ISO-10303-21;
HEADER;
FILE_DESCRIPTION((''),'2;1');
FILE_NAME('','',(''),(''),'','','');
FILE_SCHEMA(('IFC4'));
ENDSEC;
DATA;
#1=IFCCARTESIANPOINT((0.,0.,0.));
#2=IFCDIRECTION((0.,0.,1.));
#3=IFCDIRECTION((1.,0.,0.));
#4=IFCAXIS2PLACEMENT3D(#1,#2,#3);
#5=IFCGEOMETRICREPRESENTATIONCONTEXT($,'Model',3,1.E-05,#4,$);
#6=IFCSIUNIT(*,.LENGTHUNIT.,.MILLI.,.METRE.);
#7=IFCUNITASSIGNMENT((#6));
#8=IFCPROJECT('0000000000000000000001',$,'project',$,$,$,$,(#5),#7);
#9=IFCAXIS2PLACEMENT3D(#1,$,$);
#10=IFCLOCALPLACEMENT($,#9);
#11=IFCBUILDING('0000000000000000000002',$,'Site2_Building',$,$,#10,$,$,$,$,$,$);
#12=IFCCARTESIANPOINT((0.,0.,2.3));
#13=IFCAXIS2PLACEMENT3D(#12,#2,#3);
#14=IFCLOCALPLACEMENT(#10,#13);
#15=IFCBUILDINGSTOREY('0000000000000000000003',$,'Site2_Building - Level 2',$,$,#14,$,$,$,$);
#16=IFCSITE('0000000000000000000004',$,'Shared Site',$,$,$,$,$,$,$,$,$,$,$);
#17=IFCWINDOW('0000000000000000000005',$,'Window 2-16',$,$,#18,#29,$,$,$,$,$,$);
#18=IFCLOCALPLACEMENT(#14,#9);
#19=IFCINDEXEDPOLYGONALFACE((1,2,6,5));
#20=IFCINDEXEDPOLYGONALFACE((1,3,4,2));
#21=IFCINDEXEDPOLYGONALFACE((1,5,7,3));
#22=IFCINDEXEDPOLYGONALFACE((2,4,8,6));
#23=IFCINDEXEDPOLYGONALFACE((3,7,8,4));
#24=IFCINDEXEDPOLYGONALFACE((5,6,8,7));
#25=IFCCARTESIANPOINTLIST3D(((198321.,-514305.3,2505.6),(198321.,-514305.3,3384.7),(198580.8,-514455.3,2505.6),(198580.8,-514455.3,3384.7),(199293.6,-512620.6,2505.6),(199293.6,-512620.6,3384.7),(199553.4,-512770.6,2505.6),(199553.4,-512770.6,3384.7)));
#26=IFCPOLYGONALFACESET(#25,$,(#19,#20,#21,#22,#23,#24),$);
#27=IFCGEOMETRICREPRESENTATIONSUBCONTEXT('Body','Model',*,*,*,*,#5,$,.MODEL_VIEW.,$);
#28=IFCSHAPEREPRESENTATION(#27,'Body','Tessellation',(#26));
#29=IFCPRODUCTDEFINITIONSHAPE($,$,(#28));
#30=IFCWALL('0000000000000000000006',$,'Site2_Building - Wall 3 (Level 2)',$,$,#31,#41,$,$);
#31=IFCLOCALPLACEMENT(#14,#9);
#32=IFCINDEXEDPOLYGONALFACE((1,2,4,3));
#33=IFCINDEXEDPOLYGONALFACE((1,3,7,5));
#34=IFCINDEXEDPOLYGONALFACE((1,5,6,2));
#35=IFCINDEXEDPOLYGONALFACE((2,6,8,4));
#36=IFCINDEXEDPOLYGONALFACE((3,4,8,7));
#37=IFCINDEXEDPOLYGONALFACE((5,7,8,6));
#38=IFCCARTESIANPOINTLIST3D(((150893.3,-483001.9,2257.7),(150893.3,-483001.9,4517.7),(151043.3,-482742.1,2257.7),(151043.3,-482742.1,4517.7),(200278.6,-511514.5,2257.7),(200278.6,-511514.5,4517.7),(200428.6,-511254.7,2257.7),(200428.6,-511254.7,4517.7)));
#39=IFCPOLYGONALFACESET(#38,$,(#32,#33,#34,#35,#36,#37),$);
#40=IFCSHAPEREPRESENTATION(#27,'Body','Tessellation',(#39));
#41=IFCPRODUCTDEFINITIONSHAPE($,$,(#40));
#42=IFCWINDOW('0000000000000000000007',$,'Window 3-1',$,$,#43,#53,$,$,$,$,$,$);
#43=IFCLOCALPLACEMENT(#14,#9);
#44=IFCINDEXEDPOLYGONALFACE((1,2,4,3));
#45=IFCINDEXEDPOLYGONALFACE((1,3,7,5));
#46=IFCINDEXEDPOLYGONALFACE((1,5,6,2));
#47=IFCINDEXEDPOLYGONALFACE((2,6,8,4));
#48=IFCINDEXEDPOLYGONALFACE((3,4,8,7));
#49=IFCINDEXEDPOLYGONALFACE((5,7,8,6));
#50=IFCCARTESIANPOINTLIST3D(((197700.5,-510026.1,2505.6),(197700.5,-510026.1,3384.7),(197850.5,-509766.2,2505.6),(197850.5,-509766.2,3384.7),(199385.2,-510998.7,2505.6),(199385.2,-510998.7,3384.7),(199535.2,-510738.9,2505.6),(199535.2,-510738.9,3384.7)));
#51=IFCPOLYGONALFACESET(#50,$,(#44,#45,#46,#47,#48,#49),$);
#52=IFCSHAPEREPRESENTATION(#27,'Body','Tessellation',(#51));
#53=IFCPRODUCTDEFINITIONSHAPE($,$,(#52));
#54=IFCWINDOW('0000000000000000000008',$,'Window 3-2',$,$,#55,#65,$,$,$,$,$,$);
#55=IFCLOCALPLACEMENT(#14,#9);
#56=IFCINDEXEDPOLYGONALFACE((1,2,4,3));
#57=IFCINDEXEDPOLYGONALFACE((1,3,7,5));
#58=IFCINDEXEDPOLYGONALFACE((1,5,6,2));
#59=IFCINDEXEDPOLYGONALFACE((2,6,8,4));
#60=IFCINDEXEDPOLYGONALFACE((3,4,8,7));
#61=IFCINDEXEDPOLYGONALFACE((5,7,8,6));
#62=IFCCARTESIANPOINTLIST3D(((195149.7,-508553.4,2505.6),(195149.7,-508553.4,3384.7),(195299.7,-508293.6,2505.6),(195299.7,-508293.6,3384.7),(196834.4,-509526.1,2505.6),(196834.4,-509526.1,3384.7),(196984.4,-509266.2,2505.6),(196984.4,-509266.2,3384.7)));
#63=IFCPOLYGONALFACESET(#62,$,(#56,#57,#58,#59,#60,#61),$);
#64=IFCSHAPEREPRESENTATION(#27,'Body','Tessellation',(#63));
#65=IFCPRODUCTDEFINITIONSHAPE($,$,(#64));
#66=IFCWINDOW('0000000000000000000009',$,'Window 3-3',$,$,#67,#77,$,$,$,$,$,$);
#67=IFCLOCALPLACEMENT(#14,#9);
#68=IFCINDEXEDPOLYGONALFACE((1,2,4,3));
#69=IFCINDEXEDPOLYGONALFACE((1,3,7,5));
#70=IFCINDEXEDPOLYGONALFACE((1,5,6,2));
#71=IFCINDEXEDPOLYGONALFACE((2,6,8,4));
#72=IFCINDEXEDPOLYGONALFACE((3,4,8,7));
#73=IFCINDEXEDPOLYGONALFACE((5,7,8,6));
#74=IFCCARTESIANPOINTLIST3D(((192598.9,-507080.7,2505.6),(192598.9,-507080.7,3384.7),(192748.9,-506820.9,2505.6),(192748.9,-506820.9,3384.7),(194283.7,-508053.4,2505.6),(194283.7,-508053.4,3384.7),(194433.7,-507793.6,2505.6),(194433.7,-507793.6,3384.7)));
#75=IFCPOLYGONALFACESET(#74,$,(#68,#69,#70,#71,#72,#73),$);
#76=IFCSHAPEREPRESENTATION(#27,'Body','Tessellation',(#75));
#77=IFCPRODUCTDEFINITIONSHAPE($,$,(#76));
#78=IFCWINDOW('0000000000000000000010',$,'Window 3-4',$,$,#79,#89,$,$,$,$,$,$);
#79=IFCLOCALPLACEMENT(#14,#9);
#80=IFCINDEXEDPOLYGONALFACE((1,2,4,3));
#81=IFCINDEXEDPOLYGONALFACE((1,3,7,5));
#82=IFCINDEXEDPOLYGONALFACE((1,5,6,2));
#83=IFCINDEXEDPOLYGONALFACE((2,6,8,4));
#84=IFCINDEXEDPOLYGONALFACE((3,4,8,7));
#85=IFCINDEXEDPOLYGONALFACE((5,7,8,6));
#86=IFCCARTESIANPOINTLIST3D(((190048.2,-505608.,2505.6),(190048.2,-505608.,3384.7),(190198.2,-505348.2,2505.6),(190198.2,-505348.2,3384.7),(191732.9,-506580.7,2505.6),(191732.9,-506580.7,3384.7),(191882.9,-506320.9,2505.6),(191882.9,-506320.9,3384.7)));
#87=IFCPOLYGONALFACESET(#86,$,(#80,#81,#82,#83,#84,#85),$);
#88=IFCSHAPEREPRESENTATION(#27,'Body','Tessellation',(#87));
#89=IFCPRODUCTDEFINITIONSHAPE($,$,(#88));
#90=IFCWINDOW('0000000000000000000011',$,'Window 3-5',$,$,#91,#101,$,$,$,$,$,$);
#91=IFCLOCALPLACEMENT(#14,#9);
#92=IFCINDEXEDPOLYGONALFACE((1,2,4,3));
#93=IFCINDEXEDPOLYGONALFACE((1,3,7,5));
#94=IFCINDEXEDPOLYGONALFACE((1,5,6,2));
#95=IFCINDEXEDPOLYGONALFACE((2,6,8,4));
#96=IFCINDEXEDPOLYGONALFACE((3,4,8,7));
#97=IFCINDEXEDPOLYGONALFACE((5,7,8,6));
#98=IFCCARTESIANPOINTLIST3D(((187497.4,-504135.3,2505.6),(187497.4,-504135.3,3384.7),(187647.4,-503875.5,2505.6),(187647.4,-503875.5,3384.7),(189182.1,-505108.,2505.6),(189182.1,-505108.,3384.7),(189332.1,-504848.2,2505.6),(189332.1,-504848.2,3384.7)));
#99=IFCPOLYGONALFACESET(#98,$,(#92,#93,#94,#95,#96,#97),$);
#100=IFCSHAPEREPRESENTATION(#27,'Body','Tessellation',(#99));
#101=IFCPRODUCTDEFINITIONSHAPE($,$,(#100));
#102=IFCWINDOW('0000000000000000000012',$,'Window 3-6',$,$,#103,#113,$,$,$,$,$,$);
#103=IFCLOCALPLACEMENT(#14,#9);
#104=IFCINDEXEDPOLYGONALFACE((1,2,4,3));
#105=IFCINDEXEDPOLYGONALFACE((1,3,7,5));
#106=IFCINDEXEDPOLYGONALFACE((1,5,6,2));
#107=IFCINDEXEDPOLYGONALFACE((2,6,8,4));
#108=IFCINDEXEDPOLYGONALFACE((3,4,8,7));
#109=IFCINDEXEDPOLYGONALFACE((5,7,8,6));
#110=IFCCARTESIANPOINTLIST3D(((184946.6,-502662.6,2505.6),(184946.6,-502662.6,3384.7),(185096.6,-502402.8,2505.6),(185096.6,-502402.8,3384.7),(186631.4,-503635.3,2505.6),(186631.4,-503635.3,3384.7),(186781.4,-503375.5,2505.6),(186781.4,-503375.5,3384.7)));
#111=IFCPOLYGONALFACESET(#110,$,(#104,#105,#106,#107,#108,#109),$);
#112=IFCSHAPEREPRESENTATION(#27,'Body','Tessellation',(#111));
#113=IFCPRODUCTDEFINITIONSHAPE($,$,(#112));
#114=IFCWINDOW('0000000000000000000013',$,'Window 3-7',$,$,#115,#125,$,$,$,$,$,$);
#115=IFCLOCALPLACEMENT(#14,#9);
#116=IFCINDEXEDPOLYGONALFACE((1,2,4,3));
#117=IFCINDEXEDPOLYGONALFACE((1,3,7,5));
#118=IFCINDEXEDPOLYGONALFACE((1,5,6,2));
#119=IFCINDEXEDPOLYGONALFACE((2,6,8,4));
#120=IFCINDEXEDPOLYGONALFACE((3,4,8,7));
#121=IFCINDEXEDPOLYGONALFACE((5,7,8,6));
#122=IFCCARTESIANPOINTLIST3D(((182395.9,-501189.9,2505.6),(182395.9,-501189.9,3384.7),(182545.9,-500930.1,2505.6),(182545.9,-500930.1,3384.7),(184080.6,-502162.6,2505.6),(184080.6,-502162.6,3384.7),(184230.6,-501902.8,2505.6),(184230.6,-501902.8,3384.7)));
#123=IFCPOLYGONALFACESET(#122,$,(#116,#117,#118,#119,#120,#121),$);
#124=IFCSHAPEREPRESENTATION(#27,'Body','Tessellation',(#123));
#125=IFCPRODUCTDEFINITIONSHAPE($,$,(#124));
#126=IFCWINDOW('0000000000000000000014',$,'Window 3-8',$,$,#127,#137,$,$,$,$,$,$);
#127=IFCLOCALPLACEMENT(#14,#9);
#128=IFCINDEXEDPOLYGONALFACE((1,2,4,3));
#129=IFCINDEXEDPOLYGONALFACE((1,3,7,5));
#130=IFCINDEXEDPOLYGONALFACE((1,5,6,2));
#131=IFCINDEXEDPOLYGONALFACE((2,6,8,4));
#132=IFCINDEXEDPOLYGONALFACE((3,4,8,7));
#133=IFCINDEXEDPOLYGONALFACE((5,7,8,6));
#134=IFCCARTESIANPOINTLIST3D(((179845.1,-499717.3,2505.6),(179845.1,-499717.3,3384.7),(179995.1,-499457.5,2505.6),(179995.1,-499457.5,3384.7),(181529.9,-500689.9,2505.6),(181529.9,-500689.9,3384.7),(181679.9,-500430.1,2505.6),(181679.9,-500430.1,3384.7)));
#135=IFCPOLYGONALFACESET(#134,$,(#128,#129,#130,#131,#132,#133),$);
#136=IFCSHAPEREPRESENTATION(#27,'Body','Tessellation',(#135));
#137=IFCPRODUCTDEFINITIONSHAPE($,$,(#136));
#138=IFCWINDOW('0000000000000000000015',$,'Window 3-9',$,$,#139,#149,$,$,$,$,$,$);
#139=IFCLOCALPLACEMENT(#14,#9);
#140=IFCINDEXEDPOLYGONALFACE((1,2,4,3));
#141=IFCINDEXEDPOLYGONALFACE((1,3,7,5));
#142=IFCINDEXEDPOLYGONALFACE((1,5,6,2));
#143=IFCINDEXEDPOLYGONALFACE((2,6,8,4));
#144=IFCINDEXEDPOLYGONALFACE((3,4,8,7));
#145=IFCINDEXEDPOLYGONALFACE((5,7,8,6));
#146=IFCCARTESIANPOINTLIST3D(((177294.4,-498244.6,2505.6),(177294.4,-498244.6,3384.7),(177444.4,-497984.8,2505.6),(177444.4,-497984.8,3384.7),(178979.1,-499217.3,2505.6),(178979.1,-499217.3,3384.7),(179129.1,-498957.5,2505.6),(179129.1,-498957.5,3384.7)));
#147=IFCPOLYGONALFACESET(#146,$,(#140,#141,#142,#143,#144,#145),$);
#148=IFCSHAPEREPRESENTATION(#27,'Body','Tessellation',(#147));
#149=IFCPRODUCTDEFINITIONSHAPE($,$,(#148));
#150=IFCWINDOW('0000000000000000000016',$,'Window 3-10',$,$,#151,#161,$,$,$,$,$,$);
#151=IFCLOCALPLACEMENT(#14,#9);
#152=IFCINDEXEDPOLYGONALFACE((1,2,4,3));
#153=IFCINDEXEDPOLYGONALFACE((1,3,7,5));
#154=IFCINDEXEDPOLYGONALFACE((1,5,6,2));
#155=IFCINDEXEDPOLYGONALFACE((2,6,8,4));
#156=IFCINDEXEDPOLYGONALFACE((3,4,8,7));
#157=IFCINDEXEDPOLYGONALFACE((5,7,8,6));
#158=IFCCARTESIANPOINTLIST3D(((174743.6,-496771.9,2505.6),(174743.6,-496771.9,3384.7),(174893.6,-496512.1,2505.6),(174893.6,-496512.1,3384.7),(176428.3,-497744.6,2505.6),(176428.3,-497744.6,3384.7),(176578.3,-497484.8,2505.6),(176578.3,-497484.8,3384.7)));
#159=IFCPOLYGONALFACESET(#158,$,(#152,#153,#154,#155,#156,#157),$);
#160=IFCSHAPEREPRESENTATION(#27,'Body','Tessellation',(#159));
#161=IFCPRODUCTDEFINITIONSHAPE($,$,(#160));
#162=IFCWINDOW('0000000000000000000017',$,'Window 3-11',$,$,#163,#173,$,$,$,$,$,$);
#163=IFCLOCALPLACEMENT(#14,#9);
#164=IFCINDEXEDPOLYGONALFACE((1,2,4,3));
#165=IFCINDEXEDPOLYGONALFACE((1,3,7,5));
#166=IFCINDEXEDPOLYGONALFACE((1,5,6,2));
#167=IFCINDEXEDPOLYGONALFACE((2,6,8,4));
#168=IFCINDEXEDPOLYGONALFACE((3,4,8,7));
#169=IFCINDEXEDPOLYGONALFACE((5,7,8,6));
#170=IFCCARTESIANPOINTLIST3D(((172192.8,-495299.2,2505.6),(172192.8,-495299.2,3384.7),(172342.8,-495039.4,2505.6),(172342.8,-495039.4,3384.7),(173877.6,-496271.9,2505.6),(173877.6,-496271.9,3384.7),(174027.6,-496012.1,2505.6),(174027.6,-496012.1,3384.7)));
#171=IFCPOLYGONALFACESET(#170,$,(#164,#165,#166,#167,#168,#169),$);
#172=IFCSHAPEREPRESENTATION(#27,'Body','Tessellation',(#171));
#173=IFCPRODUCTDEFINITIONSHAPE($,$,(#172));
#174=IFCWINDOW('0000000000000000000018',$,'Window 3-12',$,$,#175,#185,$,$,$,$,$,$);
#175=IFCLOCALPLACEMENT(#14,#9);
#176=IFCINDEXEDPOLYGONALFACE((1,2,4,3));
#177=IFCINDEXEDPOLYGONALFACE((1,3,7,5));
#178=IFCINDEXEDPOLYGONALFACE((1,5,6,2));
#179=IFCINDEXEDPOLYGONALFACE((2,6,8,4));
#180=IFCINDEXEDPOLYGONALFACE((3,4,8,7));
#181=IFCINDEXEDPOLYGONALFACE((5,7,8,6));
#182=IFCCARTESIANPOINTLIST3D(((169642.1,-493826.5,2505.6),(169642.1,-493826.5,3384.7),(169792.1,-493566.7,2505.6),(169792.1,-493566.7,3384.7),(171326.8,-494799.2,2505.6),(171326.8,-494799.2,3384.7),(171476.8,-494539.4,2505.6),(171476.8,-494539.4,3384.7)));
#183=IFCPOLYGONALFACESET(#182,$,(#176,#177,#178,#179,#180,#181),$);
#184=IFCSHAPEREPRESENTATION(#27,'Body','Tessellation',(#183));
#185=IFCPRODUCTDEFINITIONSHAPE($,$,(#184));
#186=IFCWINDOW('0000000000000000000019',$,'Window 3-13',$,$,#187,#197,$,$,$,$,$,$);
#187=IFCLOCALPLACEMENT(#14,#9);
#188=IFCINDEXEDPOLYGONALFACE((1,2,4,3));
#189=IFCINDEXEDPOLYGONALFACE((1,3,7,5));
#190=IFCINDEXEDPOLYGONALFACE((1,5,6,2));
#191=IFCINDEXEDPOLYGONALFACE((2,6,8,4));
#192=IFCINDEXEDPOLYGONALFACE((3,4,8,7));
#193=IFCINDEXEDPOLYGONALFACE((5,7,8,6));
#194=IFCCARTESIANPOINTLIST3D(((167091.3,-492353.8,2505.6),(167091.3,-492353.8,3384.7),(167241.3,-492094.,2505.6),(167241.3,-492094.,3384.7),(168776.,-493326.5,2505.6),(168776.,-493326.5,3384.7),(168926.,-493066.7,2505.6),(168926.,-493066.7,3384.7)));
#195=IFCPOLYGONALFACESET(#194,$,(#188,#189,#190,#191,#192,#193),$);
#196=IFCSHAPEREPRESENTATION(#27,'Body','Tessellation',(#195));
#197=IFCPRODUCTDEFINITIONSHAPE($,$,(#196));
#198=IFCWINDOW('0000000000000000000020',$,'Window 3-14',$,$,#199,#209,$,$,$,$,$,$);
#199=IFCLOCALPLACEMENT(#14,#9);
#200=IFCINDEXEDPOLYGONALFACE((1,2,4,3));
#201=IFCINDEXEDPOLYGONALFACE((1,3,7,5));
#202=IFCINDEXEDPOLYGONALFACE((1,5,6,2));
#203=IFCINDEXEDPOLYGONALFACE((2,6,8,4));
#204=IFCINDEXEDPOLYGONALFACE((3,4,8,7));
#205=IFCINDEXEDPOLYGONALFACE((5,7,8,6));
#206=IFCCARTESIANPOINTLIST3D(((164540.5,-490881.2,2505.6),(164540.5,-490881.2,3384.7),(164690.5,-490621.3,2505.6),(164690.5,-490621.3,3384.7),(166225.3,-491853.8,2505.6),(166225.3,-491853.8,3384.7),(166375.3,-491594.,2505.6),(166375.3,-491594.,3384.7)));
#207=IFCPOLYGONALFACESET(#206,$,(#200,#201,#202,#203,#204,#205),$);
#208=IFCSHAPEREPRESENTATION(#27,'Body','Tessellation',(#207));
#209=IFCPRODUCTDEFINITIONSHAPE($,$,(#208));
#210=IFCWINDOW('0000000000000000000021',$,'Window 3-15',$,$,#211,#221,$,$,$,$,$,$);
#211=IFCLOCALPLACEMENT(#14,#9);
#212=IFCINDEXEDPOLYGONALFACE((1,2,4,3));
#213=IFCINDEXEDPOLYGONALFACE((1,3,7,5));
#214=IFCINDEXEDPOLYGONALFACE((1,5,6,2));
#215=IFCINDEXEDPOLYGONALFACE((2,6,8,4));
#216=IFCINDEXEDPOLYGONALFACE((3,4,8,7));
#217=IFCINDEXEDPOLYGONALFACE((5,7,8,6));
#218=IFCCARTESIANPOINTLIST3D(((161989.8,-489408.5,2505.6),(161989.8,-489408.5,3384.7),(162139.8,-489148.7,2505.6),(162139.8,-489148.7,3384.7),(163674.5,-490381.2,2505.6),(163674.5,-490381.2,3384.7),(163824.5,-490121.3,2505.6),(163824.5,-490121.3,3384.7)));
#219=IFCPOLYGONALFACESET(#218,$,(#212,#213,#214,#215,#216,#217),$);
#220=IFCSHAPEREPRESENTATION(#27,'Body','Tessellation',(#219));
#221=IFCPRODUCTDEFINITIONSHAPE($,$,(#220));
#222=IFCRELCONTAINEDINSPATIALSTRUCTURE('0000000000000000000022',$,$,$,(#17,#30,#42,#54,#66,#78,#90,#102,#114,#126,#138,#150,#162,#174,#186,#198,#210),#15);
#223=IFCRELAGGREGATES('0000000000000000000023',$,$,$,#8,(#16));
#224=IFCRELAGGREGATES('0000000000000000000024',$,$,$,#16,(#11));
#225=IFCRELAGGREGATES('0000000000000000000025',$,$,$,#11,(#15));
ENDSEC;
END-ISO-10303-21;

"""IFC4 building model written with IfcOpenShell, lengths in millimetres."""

from ifc_helpers import new_model, si_unit, frame, origin, origin_with_axes, place, context, subcontext, project, spatial, indexed_curve, outline, extrude, element, save


model = new_model("IFC4")

# Units and contexts
model_context = context("Model", 3, precision=1e-05, world=origin_with_axes())
body_context = subcontext(model_context, "Body", "Model", "MODEL_VIEW")
ifc_project = project(units=[si_unit("LENGTHUNIT", "METRE", prefix="MILLI")], contexts=[model_context])

# Site, building, storey
site = spatial("IfcSite", under=ifc_project, Name="Shared Site")
building_placement = place(None, origin())
building = spatial("IfcBuilding", under=site, at=building_placement, Name="Site2_Building")
storey_placement = place(building_placement, frame((0.0, 0.0, 2.3), z_axis=(0.0, 0.0, 1.0), x_axis=(1.0, 0.0, 0.0)))
storey = spatial("IfcBuildingStorey", under=building, at=storey_placement, Name="Site2_Building - Level 2")

# Window
for number, where, z_axis, x_axis, name in (
    (1, (198580.8, -514455.3, 2505.6), (0.0, 0.0, 1.0), (0.5, 0.866025, 0.0), "Window 2-16"),
):
    element("IfcWindow", number, at=place(storey_placement, frame(where, z_axis=z_axis, x_axis=x_axis)), inside=storey, Name=name, context=body_context, shape_type="SweptSolid", body=[
        extrude(outline(indexed_curve([(0.0, 0.0), (0.0, 300.0), (1945.4, 300.0), (1945.4, 0.0), (0.0, 0.0)], self_intersect=False)), origin_with_axes(), (0.0, 0.0, 1.0), 879.1),
    ])

# Wall
wall_1_placement = place(storey_placement, frame((200428.6, -511254.7, 2257.7), z_axis=(0.0, 0.0, 1.0), x_axis=(-0.866025, 0.5, 0.0)))
element("IfcWall", 2, at=wall_1_placement, inside=storey, Name="Site2_Building - Wall 3 (Level 2)", context=body_context, shape_type="SweptSolid", body=[
    extrude(outline(indexed_curve([(0.0, 0.0), (0.0, 300.0), (57025.3, 300.0), (57025.3, 0.0), (0.0, 0.0)], self_intersect=False)), origin_with_axes(), (0.0, 0.0, 1.0), 2260.0),
])

# Windows
for number, where, z_axis, x_axis, name in (
    (3, (199535.2, -510738.9, 2505.6), (0.0, 0.0, 1.0), (-0.866025, 0.5, 0.0), "Window 3-1"),
    (4, (196984.4, -509266.2, 2505.6), (0.0, 0.0, 1.0), (-0.866025, 0.5, 0.0), "Window 3-2"),
    (5, (194433.7, -507793.6, 2505.6), (0.0, 0.0, 1.0), (-0.866025, 0.5, 0.0), "Window 3-3"),
    (6, (191882.9, -506320.9, 2505.6), (0.0, 0.0, 1.0), (-0.866025, 0.5, 0.0), "Window 3-4"),
    (7, (189332.1, -504848.2, 2505.6), (0.0, 0.0, 1.0), (-0.866025, 0.5, 0.0), "Window 3-5"),
    (8, (186781.4, -503375.5, 2505.6), (0.0, 0.0, 1.0), (-0.866025, 0.5, 0.0), "Window 3-6"),
    (9, (184230.6, -501902.8, 2505.6), (0.0, 0.0, 1.0), (-0.866025, 0.5, 0.0), "Window 3-7"),
    (10, (181679.9, -500430.1, 2505.6), (0.0, 0.0, 1.0), (-0.866025, 0.5, 0.0), "Window 3-8"),
    (11, (179129.1, -498957.5, 2505.6), (0.0, 0.0, 1.0), (-0.866025, 0.5, 0.0), "Window 3-9"),
    (12, (176578.3, -497484.8, 2505.6), (0.0, 0.0, 1.0), (-0.866025, 0.5, 0.0), "Window 3-10"),
    (13, (174027.6, -496012.1, 2505.6), (0.0, 0.0, 1.0), (-0.866025, 0.5, 0.0), "Window 3-11"),
    (14, (171476.8, -494539.4, 2505.6), (0.0, 0.0, 1.0), (-0.866025, 0.5, 0.0), "Window 3-12"),
    (15, (168926.0, -493066.7, 2505.6), (0.0, 0.0, 1.0), (-0.866025, 0.5, 0.0), "Window 3-13"),
    (16, (166375.3, -491594.0, 2505.6), (0.0, 0.0, 1.0), (-0.866025, 0.5, 0.0), "Window 3-14"),
    (17, (163824.5, -490121.3, 2505.6), (0.0, 0.0, 1.0), (-0.866025, 0.5, 0.0), "Window 3-15"),
):
    element("IfcWindow", number, at=place(storey_placement, frame(where, z_axis=z_axis, x_axis=x_axis)), inside=storey, Name=name, context=body_context, shape_type="SweptSolid", body=[
        extrude(outline(indexed_curve([(0.0, 0.0), (0.0, 300.0), (1945.4, 300.0), (1945.4, 0.0), (0.0, 0.0)], self_intersect=False)), origin_with_axes(), (0.0, 0.0, 1.0), 879.1),
    ])

save(model, "model.ifc")
